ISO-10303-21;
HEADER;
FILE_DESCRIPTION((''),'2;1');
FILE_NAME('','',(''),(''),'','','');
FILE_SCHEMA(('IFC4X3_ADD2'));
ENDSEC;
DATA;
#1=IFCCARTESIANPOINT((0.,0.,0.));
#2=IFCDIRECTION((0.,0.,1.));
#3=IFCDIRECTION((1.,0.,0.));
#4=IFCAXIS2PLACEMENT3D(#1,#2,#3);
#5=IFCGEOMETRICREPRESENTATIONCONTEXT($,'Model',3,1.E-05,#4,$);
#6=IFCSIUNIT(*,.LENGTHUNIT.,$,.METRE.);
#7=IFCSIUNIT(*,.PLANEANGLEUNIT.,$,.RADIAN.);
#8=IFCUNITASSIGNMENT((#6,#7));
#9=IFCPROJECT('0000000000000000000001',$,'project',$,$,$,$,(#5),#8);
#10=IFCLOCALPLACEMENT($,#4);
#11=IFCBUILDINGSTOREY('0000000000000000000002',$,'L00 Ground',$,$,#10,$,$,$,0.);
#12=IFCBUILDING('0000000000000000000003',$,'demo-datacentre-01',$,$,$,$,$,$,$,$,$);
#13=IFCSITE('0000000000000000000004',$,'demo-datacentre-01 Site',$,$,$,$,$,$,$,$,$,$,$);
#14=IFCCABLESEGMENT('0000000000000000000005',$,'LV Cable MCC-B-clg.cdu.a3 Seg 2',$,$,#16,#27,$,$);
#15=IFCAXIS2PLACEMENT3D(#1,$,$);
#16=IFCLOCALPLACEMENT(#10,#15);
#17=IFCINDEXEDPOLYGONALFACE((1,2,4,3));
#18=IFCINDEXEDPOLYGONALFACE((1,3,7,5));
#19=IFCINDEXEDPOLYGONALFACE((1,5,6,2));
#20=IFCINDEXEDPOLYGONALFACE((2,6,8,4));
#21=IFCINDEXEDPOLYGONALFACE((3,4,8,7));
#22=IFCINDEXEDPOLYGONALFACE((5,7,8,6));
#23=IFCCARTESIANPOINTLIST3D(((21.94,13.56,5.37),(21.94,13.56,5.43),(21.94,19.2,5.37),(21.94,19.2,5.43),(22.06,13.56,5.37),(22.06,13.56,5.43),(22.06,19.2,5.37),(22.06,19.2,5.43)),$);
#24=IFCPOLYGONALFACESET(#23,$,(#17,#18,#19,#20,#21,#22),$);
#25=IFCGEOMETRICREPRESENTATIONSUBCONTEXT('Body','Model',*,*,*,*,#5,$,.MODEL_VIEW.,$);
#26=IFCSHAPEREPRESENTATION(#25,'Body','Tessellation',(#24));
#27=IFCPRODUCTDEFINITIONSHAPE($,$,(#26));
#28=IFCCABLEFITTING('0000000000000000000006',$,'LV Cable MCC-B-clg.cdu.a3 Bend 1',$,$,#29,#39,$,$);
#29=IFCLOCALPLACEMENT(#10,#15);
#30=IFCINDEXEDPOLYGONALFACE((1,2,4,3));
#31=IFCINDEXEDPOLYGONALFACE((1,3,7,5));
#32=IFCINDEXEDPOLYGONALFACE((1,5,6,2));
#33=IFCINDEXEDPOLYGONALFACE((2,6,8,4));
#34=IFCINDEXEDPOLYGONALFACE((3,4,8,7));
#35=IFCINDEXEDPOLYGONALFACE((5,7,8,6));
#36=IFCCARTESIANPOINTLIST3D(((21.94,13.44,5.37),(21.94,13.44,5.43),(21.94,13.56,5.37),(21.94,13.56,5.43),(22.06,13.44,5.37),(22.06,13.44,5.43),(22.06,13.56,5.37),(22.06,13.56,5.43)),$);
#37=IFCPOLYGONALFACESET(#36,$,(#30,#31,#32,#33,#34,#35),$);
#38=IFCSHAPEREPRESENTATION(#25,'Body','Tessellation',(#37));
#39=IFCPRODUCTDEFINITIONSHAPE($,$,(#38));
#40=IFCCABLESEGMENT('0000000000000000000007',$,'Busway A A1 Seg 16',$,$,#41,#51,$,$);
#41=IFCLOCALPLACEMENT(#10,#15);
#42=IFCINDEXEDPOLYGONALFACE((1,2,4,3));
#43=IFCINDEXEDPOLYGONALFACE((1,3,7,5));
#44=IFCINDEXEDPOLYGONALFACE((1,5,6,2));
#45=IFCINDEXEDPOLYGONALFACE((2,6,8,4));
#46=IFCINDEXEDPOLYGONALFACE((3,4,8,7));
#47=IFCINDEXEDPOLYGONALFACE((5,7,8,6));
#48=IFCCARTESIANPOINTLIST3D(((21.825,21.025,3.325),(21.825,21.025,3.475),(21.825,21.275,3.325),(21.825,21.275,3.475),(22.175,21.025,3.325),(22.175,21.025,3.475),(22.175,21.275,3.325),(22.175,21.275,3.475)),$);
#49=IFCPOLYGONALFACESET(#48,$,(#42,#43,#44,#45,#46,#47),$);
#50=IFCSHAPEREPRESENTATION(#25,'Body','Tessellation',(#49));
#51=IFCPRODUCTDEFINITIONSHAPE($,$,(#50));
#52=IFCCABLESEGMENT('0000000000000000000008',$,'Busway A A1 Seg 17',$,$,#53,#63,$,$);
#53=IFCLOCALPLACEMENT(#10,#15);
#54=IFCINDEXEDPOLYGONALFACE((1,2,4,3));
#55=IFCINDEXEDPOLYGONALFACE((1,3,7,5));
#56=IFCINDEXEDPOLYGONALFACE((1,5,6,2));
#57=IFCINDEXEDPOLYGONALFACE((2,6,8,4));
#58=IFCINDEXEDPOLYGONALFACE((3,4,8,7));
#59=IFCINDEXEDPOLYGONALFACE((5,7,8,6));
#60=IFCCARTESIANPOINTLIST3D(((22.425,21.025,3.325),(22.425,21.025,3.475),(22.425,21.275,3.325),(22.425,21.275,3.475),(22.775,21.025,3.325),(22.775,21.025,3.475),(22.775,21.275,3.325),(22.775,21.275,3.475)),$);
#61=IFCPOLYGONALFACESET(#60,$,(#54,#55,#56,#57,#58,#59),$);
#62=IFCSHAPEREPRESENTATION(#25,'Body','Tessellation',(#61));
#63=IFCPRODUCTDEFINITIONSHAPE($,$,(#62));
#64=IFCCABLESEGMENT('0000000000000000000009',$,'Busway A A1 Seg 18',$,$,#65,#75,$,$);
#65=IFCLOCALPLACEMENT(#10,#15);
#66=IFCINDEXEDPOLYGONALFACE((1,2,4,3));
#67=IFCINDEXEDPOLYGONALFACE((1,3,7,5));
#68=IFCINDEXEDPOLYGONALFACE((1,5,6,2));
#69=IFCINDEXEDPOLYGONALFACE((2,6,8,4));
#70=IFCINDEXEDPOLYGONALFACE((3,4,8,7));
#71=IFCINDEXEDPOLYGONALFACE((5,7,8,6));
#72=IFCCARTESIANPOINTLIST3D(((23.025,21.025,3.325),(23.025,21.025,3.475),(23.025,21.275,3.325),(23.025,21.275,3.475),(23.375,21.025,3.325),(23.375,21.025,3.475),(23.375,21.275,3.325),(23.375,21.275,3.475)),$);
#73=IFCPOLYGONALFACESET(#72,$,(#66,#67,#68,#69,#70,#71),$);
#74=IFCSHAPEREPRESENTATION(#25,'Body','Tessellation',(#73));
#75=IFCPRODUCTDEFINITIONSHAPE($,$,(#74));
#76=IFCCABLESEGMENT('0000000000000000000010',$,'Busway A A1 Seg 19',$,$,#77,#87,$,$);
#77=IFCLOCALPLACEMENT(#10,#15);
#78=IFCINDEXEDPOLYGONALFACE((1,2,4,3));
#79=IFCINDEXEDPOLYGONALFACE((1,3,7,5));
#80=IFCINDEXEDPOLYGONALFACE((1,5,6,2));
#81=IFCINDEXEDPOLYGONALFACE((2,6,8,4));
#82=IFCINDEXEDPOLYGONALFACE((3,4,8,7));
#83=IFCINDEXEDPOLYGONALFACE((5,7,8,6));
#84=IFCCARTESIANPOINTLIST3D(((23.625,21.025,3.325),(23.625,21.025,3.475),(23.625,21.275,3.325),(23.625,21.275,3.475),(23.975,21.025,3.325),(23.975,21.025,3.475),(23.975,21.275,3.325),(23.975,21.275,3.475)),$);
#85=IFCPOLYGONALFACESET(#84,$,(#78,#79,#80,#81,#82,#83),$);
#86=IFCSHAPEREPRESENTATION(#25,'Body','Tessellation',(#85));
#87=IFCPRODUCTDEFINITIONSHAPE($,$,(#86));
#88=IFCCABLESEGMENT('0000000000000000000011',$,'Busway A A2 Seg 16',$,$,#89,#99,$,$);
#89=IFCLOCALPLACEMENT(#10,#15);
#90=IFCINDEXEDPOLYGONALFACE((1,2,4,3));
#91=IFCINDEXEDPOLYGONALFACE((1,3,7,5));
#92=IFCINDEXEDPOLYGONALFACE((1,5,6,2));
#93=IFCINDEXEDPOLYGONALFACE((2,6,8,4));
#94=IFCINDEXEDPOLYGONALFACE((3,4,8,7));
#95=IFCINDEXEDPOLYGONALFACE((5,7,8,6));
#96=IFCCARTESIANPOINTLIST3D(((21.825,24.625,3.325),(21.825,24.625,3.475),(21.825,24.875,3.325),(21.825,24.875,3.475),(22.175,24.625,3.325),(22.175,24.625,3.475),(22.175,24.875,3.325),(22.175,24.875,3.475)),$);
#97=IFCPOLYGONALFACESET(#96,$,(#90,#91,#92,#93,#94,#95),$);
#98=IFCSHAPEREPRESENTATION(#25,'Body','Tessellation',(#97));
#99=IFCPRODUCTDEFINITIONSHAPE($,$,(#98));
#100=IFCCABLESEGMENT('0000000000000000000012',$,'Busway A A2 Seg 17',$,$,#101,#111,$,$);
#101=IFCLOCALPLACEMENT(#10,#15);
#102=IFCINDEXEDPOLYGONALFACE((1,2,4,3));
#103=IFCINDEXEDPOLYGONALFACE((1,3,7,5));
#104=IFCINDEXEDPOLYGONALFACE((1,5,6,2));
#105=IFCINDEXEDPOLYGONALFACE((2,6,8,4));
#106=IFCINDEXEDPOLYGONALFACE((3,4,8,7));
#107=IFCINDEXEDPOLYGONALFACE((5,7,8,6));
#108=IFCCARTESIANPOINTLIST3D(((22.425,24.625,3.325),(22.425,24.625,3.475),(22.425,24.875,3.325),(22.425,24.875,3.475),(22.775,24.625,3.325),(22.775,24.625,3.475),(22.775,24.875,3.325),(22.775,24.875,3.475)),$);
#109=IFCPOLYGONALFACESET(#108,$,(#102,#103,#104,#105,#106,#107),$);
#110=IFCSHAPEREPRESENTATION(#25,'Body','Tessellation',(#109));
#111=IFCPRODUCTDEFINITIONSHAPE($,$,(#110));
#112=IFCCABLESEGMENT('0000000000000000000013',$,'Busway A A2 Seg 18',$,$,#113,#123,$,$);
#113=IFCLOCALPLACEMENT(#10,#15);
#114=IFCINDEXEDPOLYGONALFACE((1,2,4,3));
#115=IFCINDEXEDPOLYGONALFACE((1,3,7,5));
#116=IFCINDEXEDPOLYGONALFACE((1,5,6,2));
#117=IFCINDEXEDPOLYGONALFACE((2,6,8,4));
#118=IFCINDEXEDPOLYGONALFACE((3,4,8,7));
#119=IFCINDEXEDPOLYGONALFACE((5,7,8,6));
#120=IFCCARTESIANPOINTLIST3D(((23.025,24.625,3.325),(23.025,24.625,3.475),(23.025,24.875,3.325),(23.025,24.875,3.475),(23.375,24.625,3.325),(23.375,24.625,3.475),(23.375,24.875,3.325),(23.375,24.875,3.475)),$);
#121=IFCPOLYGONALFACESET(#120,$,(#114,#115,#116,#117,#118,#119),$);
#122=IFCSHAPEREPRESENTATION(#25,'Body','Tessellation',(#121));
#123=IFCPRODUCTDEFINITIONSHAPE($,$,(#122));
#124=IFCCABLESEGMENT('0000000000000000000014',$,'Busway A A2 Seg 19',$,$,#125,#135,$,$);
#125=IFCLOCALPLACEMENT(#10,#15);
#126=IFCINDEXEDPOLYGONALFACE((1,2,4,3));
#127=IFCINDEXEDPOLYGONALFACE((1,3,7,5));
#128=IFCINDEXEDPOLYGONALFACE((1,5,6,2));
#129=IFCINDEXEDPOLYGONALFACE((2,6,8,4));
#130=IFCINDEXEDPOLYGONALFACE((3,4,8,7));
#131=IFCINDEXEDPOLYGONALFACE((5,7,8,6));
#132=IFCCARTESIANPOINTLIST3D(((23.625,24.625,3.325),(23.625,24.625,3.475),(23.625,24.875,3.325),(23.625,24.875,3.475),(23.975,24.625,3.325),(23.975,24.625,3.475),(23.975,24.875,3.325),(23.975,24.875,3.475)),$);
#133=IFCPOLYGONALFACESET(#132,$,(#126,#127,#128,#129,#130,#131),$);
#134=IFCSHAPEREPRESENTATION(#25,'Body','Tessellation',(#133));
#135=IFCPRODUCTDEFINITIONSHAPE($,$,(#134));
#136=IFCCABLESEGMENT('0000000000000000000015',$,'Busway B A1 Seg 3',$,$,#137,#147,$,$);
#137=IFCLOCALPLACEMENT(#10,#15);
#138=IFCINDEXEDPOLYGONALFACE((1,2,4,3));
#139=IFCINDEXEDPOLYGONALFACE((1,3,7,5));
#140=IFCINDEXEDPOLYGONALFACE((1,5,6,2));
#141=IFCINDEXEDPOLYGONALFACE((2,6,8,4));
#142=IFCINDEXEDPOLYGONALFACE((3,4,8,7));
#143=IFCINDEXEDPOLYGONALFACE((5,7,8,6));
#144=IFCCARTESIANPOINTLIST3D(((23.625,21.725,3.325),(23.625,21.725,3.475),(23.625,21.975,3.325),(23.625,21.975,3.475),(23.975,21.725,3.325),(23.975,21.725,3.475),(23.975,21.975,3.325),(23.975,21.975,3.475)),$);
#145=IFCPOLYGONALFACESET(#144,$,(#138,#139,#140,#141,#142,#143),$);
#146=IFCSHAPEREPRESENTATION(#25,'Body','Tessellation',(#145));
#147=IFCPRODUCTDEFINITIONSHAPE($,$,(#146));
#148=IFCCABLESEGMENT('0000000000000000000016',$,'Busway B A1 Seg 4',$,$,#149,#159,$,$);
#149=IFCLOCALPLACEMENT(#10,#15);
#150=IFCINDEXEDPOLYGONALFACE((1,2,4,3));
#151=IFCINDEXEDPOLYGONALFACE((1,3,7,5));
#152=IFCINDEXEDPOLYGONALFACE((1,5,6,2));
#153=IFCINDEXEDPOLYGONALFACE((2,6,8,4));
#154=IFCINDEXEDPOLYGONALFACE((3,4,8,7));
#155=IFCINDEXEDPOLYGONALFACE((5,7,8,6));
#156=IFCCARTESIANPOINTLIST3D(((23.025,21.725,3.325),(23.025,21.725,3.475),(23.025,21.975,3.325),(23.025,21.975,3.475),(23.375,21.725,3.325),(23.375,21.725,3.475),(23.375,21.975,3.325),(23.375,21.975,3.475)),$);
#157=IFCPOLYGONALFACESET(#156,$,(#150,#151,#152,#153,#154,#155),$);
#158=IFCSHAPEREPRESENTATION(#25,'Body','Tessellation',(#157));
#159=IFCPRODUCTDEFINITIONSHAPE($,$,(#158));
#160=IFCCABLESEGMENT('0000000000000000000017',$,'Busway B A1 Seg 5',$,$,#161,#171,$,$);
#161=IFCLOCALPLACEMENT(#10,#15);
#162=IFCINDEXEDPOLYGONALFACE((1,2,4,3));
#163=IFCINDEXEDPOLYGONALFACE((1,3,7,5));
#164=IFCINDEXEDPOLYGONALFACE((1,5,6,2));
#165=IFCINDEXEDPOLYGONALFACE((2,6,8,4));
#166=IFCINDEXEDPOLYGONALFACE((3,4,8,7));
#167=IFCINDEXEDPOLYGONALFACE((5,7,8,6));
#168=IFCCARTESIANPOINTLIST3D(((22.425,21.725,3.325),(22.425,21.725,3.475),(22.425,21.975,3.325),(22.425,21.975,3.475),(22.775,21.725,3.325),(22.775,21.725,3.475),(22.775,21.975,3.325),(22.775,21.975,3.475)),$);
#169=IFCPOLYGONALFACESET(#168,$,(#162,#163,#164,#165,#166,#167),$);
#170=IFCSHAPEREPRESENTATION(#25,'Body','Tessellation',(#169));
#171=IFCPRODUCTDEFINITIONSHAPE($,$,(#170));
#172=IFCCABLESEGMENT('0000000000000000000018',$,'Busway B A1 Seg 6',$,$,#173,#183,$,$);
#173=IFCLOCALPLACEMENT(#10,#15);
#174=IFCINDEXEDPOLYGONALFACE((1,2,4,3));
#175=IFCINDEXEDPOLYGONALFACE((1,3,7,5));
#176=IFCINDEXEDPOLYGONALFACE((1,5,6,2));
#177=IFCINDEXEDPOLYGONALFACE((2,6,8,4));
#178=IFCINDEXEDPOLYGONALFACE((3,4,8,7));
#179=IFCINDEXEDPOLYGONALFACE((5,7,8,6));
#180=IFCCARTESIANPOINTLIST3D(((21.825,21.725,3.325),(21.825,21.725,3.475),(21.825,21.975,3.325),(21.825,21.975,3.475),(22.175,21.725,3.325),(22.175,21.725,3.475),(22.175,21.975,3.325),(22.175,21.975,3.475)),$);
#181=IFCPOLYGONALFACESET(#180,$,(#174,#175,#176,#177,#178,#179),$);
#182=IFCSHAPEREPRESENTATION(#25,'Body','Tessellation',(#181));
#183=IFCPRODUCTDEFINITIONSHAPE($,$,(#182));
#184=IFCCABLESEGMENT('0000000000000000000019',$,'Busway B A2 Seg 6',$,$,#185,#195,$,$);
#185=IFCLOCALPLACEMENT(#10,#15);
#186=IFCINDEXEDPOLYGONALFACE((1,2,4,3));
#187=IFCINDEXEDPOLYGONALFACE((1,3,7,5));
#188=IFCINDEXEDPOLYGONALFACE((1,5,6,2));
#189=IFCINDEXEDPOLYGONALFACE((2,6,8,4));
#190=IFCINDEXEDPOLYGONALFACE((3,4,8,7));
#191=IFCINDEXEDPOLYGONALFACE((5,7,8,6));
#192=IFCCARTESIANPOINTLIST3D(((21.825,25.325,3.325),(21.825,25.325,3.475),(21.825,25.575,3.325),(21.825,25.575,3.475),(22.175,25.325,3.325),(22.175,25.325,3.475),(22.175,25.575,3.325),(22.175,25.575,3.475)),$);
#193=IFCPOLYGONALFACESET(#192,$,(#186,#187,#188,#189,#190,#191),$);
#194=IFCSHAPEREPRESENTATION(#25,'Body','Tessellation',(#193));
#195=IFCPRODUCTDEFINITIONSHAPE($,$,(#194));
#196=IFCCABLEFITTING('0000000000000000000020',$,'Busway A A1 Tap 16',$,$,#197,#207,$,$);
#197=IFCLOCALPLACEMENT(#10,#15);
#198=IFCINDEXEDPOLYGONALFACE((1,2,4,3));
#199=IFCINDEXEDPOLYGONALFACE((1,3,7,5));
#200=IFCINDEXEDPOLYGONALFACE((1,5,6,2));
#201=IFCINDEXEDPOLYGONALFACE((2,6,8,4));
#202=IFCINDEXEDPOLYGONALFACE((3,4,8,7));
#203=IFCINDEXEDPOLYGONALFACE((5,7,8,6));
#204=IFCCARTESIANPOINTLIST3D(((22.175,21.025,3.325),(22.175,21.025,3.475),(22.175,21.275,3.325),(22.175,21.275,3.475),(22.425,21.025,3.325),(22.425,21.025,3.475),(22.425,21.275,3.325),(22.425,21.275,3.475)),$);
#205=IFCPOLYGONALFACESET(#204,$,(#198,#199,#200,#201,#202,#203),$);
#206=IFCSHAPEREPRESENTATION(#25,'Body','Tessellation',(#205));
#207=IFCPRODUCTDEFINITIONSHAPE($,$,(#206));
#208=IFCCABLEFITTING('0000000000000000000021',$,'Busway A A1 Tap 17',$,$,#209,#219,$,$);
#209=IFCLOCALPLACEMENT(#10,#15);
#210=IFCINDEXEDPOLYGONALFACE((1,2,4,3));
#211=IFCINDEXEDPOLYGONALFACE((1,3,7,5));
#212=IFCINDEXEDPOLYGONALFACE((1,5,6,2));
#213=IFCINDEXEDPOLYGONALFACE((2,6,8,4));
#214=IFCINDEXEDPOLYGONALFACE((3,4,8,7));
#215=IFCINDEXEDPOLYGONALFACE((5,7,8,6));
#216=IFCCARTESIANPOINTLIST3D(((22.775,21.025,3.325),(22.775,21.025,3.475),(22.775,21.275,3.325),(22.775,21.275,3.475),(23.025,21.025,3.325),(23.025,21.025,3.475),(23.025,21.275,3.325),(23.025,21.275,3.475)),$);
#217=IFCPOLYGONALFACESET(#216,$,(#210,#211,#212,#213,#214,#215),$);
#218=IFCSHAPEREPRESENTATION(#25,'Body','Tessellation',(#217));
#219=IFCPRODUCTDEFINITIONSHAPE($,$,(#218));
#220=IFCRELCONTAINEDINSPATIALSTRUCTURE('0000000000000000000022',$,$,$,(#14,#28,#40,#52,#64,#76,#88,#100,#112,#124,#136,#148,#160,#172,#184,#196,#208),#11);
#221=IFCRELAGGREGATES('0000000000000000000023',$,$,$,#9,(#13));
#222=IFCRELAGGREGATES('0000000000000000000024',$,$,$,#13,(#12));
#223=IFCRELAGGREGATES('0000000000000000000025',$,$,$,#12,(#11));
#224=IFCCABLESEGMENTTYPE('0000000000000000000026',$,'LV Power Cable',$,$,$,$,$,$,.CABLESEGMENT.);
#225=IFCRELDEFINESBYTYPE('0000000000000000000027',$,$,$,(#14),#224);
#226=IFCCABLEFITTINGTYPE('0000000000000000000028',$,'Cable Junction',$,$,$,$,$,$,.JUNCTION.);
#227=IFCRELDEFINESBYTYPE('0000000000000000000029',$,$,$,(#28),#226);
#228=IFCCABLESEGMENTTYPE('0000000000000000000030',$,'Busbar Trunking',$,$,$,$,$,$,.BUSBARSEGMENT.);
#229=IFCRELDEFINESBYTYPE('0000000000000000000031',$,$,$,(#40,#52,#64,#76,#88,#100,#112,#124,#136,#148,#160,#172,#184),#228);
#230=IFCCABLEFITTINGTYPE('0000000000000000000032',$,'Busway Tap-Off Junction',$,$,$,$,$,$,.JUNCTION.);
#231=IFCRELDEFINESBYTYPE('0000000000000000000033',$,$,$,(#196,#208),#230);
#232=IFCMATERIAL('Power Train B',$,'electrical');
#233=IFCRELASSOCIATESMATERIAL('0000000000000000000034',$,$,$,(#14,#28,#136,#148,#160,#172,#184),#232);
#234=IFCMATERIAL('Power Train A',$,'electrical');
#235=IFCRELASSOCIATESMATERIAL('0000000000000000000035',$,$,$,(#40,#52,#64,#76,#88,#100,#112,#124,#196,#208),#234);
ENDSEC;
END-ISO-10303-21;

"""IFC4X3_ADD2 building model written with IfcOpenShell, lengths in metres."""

from ifc_helpers import new_model, si_unit, frame, origin_with_axes, place, context, subcontext, project, spatial, rectangle, extrude, material, type_object, element, save


model = new_model("IFC4X3_ADD2")

# Units and contexts
model_context = context("Model", 3, precision=1e-05, world=origin_with_axes())
body_context = subcontext(model_context, "Body", "Model", "MODEL_VIEW")
ifc_project = project(units=[si_unit("LENGTHUNIT", "METRE"), si_unit("PLANEANGLEUNIT", "RADIAN")], contexts=[model_context])

# Site, building, storey
site = spatial("IfcSite", under=ifc_project, Name="demo-datacentre-01 Site")
building = spatial("IfcBuilding", under=site, Name="demo-datacentre-01")
storey_placement = place(None, origin_with_axes())
storey = spatial("IfcBuildingStorey", under=building, at=storey_placement, Name="L00 Ground", Elevation=0.0)

# Cable segment
ifc_material_1 = material(Name="Power Train B", Category="electrical")
cable_segment_type_1 = type_object("IfcCableSegmentType", Name="LV Power Cable", PredefinedType="CABLESEGMENT")
cable_segment_placement = place(storey_placement, frame((22.0, 13.56, 5.4), z_axis=(0.0, 1.0, 0.0), x_axis=(-1.0, 0.0, 0.0)))
element("IfcCableSegment", 1, at=cable_segment_placement, inside=storey, type_object=cable_segment_type_1, material=ifc_material_1, Name="LV Cable MCC-B-clg.cdu.a3 Seg 2", context=body_context, shape_type="SweptSolid", body=[
    extrude(rectangle(XDim=0.12, YDim=0.06), origin_with_axes(), (0.0, 0.0, 1.0), 5.64),
])

# Cable fitting
cable_fitting_type_1 = type_object("IfcCableFittingType", Name="Cable Junction", PredefinedType="JUNCTION")
cable_fitting_placement = place(storey_placement, frame((22.0, 13.5, 5.37), z_axis=(0.0, 0.0, 1.0), x_axis=(1.0, 0.0, 0.0)))
element("IfcCableFitting", 2, at=cable_fitting_placement, inside=storey, type_object=cable_fitting_type_1, material=ifc_material_1, Name="LV Cable MCC-B-clg.cdu.a3 Bend 1", context=body_context, shape_type="SweptSolid", body=[
    extrude(rectangle(XDim=0.12, YDim=0.12), origin_with_axes(), (0.0, 0.0, 1.0), 0.06),
])

# Cable segments
ifc_material_2 = material(Name="Power Train A", Category="electrical")
cable_segment_type_2 = type_object("IfcCableSegmentType", Name="Busbar Trunking", PredefinedType="BUSBARSEGMENT")
for number, where, z_axis, x_axis, name in (
    (3, (21.825, 21.15, 3.4), (1.0, 0.0, 0.0), (0.0, 1.0, 0.0), "Busway A A1 Seg 16"),
    (4, (22.425, 21.15, 3.4), (1.0, 0.0, 0.0), (0.0, 1.0, 0.0), "Busway A A1 Seg 17"),
):
    element("IfcCableSegment", number, at=place(storey_placement, frame(where, z_axis=z_axis, x_axis=x_axis)), inside=storey, type_object=cable_segment_type_2, material=ifc_material_2, Name=name, context=body_context, shape_type="SweptSolid", body=[
        extrude(rectangle(XDim=0.25, YDim=0.15), origin_with_axes(), (0.0, 0.0, 1.0), 0.35),
    ])
for number, where, z_axis, x_axis, name in (
    (5, (23.025, 21.15, 3.4), (1.0, 0.0, 0.0), (0.0, 1.0, 0.0), "Busway A A1 Seg 18"),
    (6, (23.625, 21.15, 3.4), (1.0, 0.0, 0.0), (0.0, 1.0, 0.0), "Busway A A1 Seg 19"),
):
    element("IfcCableSegment", number, at=place(storey_placement, frame(where, z_axis=z_axis, x_axis=x_axis)), inside=storey, type_object=cable_segment_type_2, material=ifc_material_2, Name=name, context=body_context, shape_type="SweptSolid", body=[
        extrude(rectangle(XDim=0.25, YDim=0.15), origin_with_axes(), (0.0, 0.0, 1.0), 0.35),
    ])
for number, where, z_axis, x_axis, name in (
    (7, (21.825, 24.75, 3.4), (1.0, 0.0, 0.0), (0.0, 1.0, 0.0), "Busway A A2 Seg 16"),
    (8, (22.425, 24.75, 3.4), (1.0, 0.0, 0.0), (0.0, 1.0, 0.0), "Busway A A2 Seg 17"),
):
    element("IfcCableSegment", number, at=place(storey_placement, frame(where, z_axis=z_axis, x_axis=x_axis)), inside=storey, type_object=cable_segment_type_2, material=ifc_material_2, Name=name, context=body_context, shape_type="SweptSolid", body=[
        extrude(rectangle(XDim=0.25, YDim=0.15), origin_with_axes(), (0.0, 0.0, 1.0), 0.35),
    ])
for number, where, z_axis, x_axis, name in (
    (9, (23.025, 24.75, 3.4), (1.0, 0.0, 0.0), (0.0, 1.0, 0.0), "Busway A A2 Seg 18"),
    (10, (23.625, 24.75, 3.4), (1.0, 0.0, 0.0), (0.0, 1.0, 0.0), "Busway A A2 Seg 19"),
):
    element("IfcCableSegment", number, at=place(storey_placement, frame(where, z_axis=z_axis, x_axis=x_axis)), inside=storey, type_object=cable_segment_type_2, material=ifc_material_2, Name=name, context=body_context, shape_type="SweptSolid", body=[
        extrude(rectangle(XDim=0.25, YDim=0.15), origin_with_axes(), (0.0, 0.0, 1.0), 0.35),
    ])
for number, where, z_axis, x_axis, name in (
    (11, (23.975, 21.85, 3.4), (-1.0, 0.0, 0.0), (0.0, -1.0, 0.0), "Busway B A1 Seg 3"),
    (12, (23.375, 21.85, 3.4), (-1.0, 0.0, 0.0), (0.0, -1.0, 0.0), "Busway B A1 Seg 4"),
):
    element("IfcCableSegment", number, at=place(storey_placement, frame(where, z_axis=z_axis, x_axis=x_axis)), inside=storey, type_object=cable_segment_type_2, material=ifc_material_1, Name=name, context=body_context, shape_type="SweptSolid", body=[
        extrude(rectangle(XDim=0.25, YDim=0.15), origin_with_axes(), (0.0, 0.0, 1.0), 0.35),
    ])
for number, where, z_axis, x_axis, name in (
    (13, (22.775, 21.85, 3.4), (-1.0, 0.0, 0.0), (0.0, -1.0, 0.0), "Busway B A1 Seg 5"),
    (14, (22.175, 21.85, 3.4), (-1.0, 0.0, 0.0), (0.0, -1.0, 0.0), "Busway B A1 Seg 6"),
    (15, (22.175, 25.45, 3.4), (-1.0, 0.0, 0.0), (0.0, -1.0, 0.0), "Busway B A2 Seg 6"),
):
    element("IfcCableSegment", number, at=place(storey_placement, frame(where, z_axis=z_axis, x_axis=x_axis)), inside=storey, type_object=cable_segment_type_2, material=ifc_material_1, Name=name, context=body_context, shape_type="SweptSolid", body=[
        extrude(rectangle(XDim=0.25, YDim=0.15), origin_with_axes(), (0.0, 0.0, 1.0), 0.35),
    ])

# Cable fittings
cable_fitting_type_2 = type_object("IfcCableFittingType", Name="Busway Tap-Off Junction", PredefinedType="JUNCTION")
for number, where, z_axis, x_axis, name in (
    (16, (22.3, 21.15, 3.325), (0.0, 0.0, 1.0), (1.0, 0.0, 0.0), "Busway A A1 Tap 16"),
    (17, (22.9, 21.15, 3.325), (0.0, 0.0, 1.0), (1.0, 0.0, 0.0), "Busway A A1 Tap 17"),
):
    element("IfcCableFitting", number, at=place(storey_placement, frame(where, z_axis=z_axis, x_axis=x_axis)), inside=storey, type_object=cable_fitting_type_2, material=ifc_material_2, Name=name, context=body_context, shape_type="SweptSolid", body=[
        extrude(rectangle(XDim=0.25, YDim=0.25), origin_with_axes(), (0.0, 0.0, 1.0), 0.15),
    ])

save(model, "model.ifc")
